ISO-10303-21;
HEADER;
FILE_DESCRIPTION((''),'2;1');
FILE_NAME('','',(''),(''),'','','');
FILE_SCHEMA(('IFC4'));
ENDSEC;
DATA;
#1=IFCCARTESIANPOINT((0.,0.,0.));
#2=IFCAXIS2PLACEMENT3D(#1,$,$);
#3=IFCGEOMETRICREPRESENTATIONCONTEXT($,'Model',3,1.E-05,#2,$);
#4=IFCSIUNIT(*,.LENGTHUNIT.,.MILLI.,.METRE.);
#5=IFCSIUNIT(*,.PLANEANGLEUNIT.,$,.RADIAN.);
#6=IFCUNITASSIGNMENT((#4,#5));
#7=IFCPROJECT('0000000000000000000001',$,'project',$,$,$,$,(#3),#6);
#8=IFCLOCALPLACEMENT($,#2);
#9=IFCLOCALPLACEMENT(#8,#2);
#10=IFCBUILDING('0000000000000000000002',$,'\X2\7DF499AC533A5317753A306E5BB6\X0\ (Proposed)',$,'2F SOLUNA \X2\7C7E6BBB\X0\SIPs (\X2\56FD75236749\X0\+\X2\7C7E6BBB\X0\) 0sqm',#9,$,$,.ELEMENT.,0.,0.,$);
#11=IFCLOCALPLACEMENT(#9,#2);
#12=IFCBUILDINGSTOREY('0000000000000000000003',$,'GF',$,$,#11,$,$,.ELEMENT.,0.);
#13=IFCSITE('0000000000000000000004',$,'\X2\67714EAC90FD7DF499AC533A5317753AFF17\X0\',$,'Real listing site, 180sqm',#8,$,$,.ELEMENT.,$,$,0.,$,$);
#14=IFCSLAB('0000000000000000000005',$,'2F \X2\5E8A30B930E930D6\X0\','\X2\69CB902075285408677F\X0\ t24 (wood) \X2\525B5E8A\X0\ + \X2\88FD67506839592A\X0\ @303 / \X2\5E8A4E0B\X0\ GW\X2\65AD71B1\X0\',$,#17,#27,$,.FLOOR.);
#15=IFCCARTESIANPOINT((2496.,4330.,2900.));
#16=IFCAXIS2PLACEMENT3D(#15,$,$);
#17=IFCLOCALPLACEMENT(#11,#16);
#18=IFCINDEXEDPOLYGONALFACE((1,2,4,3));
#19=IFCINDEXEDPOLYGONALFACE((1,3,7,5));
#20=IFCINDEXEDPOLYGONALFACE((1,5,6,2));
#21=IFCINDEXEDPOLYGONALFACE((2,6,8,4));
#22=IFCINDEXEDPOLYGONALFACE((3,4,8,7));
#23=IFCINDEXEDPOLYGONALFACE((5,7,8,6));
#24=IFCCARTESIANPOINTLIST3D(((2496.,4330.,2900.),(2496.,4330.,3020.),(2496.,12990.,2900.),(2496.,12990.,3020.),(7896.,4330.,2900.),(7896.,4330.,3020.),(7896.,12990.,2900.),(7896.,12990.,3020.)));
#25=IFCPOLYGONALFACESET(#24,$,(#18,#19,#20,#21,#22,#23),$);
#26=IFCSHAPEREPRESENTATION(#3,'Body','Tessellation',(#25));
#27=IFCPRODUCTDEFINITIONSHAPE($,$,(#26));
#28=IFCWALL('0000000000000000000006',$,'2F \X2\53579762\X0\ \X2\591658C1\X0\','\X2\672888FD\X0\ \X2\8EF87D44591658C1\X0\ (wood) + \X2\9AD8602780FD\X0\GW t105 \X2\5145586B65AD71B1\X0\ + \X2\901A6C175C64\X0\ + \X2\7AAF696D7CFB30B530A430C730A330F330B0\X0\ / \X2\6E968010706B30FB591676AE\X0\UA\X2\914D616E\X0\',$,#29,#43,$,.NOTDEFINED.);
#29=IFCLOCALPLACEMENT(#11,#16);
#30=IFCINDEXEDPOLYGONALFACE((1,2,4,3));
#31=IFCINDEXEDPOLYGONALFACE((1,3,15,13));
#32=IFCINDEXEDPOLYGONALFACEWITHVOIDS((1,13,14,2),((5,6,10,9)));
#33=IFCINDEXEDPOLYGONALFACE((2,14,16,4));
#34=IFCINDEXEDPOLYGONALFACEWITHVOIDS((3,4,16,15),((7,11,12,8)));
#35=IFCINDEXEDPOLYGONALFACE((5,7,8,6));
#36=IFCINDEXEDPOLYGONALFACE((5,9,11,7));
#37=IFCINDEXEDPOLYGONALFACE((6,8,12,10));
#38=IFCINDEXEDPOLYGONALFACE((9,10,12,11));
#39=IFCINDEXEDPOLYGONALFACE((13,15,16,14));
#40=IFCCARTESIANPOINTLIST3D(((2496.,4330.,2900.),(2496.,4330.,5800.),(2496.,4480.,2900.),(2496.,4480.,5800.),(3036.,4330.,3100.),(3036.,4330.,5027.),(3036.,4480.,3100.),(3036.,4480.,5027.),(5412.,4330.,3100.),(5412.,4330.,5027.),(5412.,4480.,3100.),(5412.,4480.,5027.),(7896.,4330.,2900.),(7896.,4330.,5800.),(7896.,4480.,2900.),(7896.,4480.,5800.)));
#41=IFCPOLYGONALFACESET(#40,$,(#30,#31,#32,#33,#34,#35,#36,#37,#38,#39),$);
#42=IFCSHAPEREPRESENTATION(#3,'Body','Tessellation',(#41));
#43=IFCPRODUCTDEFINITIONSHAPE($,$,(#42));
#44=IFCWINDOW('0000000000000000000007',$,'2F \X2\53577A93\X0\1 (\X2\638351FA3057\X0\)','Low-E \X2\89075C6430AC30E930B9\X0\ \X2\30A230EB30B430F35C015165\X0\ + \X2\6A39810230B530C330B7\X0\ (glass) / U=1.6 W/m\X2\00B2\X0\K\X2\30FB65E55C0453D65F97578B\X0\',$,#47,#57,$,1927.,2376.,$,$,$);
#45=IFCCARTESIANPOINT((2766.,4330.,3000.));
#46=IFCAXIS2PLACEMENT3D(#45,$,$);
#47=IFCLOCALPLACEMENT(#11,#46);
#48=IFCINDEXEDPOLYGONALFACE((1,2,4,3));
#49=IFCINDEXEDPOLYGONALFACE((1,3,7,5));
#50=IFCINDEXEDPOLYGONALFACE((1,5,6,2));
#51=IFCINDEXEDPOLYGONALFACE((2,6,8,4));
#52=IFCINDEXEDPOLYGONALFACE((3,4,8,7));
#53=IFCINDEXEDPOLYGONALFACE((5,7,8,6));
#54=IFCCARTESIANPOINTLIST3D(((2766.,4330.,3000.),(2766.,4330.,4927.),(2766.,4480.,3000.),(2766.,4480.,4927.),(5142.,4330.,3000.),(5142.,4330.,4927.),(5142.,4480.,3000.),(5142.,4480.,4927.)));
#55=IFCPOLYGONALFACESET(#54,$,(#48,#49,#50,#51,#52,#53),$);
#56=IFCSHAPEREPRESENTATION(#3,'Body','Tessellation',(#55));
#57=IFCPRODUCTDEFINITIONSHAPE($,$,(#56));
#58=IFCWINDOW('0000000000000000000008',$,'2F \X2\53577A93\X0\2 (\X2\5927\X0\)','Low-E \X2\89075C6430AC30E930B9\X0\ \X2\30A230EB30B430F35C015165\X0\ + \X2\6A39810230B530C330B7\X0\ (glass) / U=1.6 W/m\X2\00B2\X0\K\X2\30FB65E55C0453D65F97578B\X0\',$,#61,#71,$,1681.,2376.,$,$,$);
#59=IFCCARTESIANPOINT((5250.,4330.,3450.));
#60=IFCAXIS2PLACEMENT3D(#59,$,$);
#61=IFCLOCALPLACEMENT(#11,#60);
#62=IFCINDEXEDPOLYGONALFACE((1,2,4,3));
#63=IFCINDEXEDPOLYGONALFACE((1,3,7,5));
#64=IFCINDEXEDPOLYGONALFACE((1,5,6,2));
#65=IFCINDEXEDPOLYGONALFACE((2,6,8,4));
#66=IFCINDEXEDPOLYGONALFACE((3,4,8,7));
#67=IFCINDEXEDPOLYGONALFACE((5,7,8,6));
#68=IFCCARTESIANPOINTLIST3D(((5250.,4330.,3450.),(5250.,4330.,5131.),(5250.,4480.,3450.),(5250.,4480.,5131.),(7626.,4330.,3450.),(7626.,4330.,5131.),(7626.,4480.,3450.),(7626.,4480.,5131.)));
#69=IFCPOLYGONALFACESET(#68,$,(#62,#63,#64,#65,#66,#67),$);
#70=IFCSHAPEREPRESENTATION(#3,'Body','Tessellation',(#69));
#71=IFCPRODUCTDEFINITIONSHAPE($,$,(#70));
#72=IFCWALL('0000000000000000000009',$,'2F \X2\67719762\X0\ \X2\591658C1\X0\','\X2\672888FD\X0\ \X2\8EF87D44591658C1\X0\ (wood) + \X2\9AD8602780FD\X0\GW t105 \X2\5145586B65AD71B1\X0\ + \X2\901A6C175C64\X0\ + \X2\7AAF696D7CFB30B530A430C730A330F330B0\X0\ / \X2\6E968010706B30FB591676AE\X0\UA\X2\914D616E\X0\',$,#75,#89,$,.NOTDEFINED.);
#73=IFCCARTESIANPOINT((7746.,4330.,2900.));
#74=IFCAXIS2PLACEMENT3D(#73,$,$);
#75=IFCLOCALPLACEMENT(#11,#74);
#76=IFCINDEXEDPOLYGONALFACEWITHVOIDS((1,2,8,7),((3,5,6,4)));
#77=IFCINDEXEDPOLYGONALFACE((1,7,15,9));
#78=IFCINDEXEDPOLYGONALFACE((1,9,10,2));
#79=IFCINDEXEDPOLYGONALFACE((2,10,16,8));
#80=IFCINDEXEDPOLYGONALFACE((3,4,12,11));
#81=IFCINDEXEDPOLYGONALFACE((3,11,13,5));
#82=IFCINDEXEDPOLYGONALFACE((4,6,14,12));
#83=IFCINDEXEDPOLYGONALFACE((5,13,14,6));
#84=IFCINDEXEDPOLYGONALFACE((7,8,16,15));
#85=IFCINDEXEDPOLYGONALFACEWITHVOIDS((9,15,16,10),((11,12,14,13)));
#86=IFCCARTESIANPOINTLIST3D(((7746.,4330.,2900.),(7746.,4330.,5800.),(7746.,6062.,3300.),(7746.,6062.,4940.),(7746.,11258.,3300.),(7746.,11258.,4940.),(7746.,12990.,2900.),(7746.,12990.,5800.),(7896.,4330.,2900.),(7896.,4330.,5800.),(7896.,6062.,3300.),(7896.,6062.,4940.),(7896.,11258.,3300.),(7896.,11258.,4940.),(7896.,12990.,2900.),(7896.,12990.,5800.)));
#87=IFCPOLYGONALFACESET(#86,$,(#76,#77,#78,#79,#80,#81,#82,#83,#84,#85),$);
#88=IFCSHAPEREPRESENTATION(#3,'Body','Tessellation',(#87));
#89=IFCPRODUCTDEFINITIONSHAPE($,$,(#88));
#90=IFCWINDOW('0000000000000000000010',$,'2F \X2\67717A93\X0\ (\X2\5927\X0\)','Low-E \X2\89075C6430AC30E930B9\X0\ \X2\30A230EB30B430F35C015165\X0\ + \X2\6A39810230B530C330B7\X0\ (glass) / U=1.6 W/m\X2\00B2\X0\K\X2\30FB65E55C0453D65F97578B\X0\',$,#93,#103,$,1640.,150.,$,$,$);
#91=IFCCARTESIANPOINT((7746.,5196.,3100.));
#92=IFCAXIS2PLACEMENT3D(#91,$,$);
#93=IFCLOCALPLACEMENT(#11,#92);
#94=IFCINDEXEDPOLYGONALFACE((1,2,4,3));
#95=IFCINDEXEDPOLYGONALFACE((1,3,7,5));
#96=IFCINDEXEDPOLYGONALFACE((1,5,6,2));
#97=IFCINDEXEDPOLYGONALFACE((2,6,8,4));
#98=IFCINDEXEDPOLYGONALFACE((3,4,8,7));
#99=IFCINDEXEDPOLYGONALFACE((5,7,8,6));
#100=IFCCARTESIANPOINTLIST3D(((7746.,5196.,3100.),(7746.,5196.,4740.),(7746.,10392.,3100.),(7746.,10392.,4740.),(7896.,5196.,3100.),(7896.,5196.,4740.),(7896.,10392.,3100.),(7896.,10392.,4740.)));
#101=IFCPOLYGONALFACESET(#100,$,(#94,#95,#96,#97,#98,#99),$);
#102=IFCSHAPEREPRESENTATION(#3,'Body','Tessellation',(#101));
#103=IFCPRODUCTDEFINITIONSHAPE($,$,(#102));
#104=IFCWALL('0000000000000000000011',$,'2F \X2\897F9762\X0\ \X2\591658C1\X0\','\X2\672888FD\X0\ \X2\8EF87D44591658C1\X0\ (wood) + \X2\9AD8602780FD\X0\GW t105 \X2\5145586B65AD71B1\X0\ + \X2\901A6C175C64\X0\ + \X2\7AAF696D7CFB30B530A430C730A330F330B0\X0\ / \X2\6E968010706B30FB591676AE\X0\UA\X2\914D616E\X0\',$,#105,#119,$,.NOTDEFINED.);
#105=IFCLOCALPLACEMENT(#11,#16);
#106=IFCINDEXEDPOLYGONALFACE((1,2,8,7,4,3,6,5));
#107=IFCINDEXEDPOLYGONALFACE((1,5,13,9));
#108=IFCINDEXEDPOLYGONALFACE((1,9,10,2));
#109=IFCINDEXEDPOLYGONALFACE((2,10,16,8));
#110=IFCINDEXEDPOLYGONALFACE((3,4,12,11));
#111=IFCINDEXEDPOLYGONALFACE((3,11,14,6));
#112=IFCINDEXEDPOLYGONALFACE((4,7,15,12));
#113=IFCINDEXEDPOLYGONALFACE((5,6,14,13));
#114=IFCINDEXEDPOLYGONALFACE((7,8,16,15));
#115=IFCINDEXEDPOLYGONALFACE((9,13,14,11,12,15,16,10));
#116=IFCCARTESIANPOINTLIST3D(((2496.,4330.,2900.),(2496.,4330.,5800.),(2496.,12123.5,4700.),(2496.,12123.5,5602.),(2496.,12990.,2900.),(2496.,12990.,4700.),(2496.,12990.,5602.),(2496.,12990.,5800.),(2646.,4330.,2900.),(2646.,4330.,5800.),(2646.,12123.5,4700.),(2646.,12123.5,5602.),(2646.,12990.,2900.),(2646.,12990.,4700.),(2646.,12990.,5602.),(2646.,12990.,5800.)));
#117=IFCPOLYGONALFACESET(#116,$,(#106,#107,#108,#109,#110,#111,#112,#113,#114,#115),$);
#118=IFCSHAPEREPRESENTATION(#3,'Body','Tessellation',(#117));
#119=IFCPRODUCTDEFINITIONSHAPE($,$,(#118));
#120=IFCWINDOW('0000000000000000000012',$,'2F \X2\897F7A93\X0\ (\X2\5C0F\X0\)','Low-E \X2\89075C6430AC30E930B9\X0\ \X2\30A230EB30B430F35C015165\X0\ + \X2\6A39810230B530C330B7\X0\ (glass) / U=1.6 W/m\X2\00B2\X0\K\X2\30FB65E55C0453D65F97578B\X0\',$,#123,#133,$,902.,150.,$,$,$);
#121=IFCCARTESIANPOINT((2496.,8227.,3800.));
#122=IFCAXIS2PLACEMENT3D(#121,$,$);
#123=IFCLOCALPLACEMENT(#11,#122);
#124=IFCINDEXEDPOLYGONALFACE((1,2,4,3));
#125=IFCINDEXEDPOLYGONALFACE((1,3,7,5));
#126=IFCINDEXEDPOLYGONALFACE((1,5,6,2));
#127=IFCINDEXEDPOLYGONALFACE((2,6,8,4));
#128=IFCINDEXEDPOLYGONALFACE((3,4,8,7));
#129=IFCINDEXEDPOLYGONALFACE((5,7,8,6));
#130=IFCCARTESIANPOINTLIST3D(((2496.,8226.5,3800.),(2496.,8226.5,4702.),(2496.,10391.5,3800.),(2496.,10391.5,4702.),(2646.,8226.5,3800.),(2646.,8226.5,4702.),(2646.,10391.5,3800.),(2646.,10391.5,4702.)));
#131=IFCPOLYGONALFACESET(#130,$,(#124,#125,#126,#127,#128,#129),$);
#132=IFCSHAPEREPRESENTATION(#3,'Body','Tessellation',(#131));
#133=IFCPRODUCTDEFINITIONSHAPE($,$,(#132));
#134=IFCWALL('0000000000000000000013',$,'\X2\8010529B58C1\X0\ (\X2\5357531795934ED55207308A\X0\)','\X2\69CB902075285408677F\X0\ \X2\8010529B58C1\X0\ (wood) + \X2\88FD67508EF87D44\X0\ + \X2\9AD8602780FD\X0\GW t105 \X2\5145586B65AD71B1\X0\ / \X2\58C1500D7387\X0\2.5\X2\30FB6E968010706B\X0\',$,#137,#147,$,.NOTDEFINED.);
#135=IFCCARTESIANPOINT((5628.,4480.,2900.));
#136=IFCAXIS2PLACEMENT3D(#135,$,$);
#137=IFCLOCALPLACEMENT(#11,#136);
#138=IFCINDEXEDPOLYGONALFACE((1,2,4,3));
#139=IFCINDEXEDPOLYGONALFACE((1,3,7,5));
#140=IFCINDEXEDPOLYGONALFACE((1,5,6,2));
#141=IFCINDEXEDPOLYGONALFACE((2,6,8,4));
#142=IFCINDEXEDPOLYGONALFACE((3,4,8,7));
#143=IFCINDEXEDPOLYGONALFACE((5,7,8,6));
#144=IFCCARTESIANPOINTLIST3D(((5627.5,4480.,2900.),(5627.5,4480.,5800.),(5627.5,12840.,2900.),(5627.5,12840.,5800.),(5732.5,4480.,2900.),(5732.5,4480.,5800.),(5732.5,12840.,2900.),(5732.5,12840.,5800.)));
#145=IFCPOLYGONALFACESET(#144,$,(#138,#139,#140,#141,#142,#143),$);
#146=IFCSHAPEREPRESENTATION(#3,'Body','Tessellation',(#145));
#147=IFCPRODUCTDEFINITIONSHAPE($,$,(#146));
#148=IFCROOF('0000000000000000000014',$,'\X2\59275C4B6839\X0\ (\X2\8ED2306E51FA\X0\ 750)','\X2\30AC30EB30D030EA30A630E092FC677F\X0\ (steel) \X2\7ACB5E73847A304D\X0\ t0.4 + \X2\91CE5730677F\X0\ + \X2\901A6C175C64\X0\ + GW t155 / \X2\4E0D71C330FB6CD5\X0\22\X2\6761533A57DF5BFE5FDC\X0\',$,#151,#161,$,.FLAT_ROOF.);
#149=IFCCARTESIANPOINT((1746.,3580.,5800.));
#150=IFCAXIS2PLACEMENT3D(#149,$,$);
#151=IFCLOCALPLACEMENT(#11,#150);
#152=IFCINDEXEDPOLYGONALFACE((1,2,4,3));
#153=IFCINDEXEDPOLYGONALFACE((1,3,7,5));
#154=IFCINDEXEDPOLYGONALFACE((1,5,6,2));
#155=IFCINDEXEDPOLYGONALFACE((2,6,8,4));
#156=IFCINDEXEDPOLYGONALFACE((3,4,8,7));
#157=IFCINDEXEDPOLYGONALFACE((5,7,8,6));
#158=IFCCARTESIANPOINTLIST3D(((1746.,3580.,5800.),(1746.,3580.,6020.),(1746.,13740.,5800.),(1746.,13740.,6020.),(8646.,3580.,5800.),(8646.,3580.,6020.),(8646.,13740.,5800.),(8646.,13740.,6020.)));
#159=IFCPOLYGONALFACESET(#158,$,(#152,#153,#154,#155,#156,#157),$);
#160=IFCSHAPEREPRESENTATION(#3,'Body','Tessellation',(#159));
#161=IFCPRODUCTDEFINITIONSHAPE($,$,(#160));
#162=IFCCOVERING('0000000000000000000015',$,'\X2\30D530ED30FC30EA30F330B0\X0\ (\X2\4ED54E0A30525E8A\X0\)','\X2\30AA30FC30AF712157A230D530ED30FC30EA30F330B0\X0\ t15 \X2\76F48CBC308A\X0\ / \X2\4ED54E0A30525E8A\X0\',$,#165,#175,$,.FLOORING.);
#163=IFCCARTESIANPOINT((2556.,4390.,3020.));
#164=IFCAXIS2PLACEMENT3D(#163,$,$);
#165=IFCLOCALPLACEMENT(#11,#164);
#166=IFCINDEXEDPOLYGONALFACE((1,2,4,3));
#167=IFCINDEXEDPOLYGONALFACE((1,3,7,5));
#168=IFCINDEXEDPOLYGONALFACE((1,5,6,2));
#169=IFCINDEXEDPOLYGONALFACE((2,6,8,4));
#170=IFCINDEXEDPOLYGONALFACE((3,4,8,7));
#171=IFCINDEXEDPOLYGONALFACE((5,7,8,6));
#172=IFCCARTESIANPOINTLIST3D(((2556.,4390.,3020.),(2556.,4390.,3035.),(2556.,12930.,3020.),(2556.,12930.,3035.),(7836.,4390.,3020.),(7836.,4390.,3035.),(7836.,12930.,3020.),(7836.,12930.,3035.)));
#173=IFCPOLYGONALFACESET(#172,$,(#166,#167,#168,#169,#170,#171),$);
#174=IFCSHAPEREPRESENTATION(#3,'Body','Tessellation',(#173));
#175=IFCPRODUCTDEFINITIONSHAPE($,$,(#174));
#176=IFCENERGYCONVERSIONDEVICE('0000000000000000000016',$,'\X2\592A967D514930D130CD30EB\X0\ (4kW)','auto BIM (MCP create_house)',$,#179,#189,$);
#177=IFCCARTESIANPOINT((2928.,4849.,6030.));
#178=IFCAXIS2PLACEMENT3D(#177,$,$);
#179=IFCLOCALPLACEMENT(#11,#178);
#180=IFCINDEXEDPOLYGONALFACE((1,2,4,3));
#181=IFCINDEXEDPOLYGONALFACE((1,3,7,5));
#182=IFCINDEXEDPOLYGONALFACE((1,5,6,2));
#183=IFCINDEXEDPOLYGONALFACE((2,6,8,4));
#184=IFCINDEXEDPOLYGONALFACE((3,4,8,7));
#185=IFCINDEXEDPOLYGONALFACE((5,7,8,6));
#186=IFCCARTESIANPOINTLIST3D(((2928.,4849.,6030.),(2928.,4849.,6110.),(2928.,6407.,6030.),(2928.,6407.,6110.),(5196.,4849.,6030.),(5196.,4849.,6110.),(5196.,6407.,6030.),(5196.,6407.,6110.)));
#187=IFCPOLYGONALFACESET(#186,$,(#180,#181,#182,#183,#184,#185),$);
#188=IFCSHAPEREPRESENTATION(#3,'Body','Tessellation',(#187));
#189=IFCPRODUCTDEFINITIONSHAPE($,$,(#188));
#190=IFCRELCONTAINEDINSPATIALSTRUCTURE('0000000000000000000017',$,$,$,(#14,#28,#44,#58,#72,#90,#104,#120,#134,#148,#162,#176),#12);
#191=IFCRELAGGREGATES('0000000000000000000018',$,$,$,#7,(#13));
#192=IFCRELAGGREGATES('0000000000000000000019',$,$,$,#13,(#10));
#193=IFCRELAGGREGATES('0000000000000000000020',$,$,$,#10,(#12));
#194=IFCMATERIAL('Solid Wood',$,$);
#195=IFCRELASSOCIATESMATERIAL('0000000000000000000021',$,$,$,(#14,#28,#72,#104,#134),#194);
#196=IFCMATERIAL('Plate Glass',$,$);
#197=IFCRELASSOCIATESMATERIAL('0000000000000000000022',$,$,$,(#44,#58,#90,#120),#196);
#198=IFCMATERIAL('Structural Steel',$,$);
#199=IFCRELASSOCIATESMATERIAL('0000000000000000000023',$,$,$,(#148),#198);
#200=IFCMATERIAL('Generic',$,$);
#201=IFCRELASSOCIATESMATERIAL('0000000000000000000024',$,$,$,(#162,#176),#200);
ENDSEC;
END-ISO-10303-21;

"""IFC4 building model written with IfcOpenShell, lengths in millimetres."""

from ifc_helpers import new_model, si_unit, frame, frame_2d, origin, place, context, project, spatial, rectangle, extrude, material, element, fill, save


model = new_model("IFC4")

# Units and contexts
model_context = context("Model", 3, precision=1e-05, world=origin())
ifc_project = project(units=[si_unit("LENGTHUNIT", "METRE", prefix="MILLI"), si_unit("PLANEANGLEUNIT", "RADIAN")], contexts=[model_context])

# Site, building, storey
site_placement = place(None, origin())
site = spatial("IfcSite", under=ifc_project, at=site_placement, Name="東京都練馬区北町７", ObjectType="Real listing site, 180sqm", CompositionType="ELEMENT", RefElevation=0.0)
building_placement = place(site_placement, origin())
building = spatial("IfcBuilding", under=site, at=building_placement, Name="練馬区北町の家 (Proposed)", ObjectType="2F SOLUNA 籾殻SIPs (国産杉+籾殻) 0sqm", CompositionType="ELEMENT", ElevationOfRefHeight=0.0, ElevationOfTerrain=0.0)
storey_placement = place(building_placement, origin())
storey = spatial("IfcBuildingStorey", under=building, at=storey_placement, Name="GF", CompositionType="ELEMENT", Elevation=0.0)

# Slab
ifc_material_1 = material(Name="Solid Wood")
slab_placement = place(storey_placement, frame((2496.0, 4330.0, 2900.0)))
element("IfcSlab", 1, at=slab_placement, inside=storey, material=ifc_material_1, Name="2F 床スラブ", Description="構造用合板 t24 (wood) 剛床 + 製材根太 @303 / 床下 GW断熱", PredefinedType="FLOOR", context=model_context, shape_type="SweptSolid", body=[
    extrude(rectangle(XDim=5400.0, YDim=8660.0, at=frame_2d((2700.0, 4330.0))), frame((2496.0, 4330.0, 2900.0)), (0.0, 0.0, 1.0), 120.0),
])

# Wall, openings, windows
wall_1_placement = place(storey_placement, frame((2496.0, 4330.0, 2900.0)))
wall_1 = element("IfcWall", 2, at=wall_1_placement, inside=storey, material=ifc_material_1, Name="2F 南面 外壁", Description="木製 軸組外壁 (wood) + 高性能GW t105 充填断熱 + 通気層 + 窯業系サイディング / 準耐火・外皮UA配慮", PredefinedType="NOTDEFINED", context=model_context, shape_type="SweptSolid", body=[
    extrude(rectangle(XDim=5400.0, YDim=150.0, at=frame_2d((2700.0, 75.0))), frame((2496.0, 4330.0, 2900.0)), (0.0, 0.0, 1.0), 2900.0),
])
opening_1_placement = place(storey_placement, frame((2766.0, 4330.0, 3000.0)))
opening_1 = element("IfcOpeningElement", 3, at=opening_1_placement, cuts=wall_1, PredefinedType="NOTDEFINED", context=model_context, shape_type="SweptSolid", body=[
    extrude(rectangle(XDim=2376.0, YDim=150.0, at=frame_2d((1188.0, 75.0))), frame((2766.0, 4330.0, 3000.0)), (0.0, 0.0, 1.0), 1927.0),
])
opening_2_placement = place(storey_placement, frame((5250.0, 4330.0, 3450.0)))
opening_2 = element("IfcOpeningElement", 4, at=opening_2_placement, cuts=wall_1, PredefinedType="NOTDEFINED", context=model_context, shape_type="SweptSolid", body=[
    extrude(rectangle(XDim=2376.0, YDim=150.0, at=frame_2d((1188.0, 75.0))), frame((5250.0, 4330.0, 3450.0)), (0.0, 0.0, 1.0), 1681.0),
])
ifc_material_2 = material(Name="Plate Glass")
window_1_placement = place(storey_placement, frame((2766.0, 4330.0, 3000.0)))
window_1 = element("IfcWindow", 5, at=window_1_placement, inside=storey, material=ifc_material_2, Name="2F 南窓1 (掃出し)", Description="Low-E 複層ガラス アルゴン封入 + 樹脂サッシ (glass) / U=1.6 W/m²K・日射取得型", OverallHeight=1927.0, OverallWidth=2376.0, context=model_context, shape_type="SweptSolid", body=[
    extrude(rectangle(XDim=2376.0, YDim=150.0, at=frame_2d((1188.0, 75.0))), frame((2766.0, 4330.0, 3000.0)), (0.0, 0.0, 1.0), 1927.0),
])
fill(opening_1, window_1)
window_2_placement = place(storey_placement, frame((5250.0, 4330.0, 3450.0)))
window_2 = element("IfcWindow", 6, at=window_2_placement, inside=storey, material=ifc_material_2, Name="2F 南窓2 (大)", Description="Low-E 複層ガラス アルゴン封入 + 樹脂サッシ (glass) / U=1.6 W/m²K・日射取得型", OverallHeight=1681.0, OverallWidth=2376.0, context=model_context, shape_type="SweptSolid", body=[
    extrude(rectangle(XDim=2376.0, YDim=150.0, at=frame_2d((1188.0, 75.0))), frame((5250.0, 4330.0, 3450.0)), (0.0, 0.0, 1.0), 1681.0),
])
fill(opening_2, window_2)

# Walls, openings, windows
wall_2_placement = place(storey_placement, frame((7746.0, 4330.0, 2900.0)))
wall_2 = element("IfcWall", 7, at=wall_2_placement, inside=storey, material=ifc_material_1, Name="2F 東面 外壁", Description="木製 軸組外壁 (wood) + 高性能GW t105 充填断熱 + 通気層 + 窯業系サイディング / 準耐火・外皮UA配慮", PredefinedType="NOTDEFINED", context=model_context, shape_type="SweptSolid", body=[
    extrude(rectangle(XDim=150.0, YDim=8660.0, at=frame_2d((75.0, 4330.0))), frame((7746.0, 4330.0, 2900.0)), (0.0, 0.0, 1.0), 2900.0),
])
opening_3_placement = place(storey_placement, frame((7746.0, 5196.0, 3100.0)))
opening_3 = element("IfcOpeningElement", 8, at=opening_3_placement, cuts=wall_2, PredefinedType="NOTDEFINED", context=model_context, shape_type="SweptSolid", body=[
    extrude(rectangle(XDim=150.0, YDim=5196.0, at=frame_2d((75.0, 2598.0))), frame((7746.0, 5196.0, 3100.0)), (0.0, 0.0, 1.0), 1640.0),
])
window_3_placement = place(storey_placement, frame((7746.0, 5196.0, 3100.0)))
window_3 = element("IfcWindow", 9, at=window_3_placement, inside=storey, material=ifc_material_2, Name="2F 東窓 (大)", Description="Low-E 複層ガラス アルゴン封入 + 樹脂サッシ (glass) / U=1.6 W/m²K・日射取得型", OverallHeight=1640.0, OverallWidth=150.0, context=model_context, shape_type="SweptSolid", body=[
    extrude(rectangle(XDim=150.0, YDim=5196.0, at=frame_2d((75.0, 2598.0))), frame((7746.0, 5196.0, 3100.0)), (0.0, 0.0, 1.0), 1640.0),
])
fill(opening_3, window_3)
wall_3_placement = place(storey_placement, frame((2496.0, 4330.0, 2900.0)))
wall_3 = element("IfcWall", 10, at=wall_3_placement, inside=storey, material=ifc_material_1, Name="2F 西面 外壁", Description="木製 軸組外壁 (wood) + 高性能GW t105 充填断熱 + 通気層 + 窯業系サイディング / 準耐火・外皮UA配慮", PredefinedType="NOTDEFINED", context=model_context, shape_type="SweptSolid", body=[
    extrude(rectangle(XDim=150.0, YDim=8660.0, at=frame_2d((75.0, 4330.0))), frame((2496.0, 4330.0, 2900.0)), (0.0, 0.0, 1.0), 2900.0),
])
opening_4_placement = place(storey_placement, frame((2496.0, 8227.0, 3800.0)))
opening_4 = element("IfcOpeningElement", 11, at=opening_4_placement, cuts=wall_3, PredefinedType="NOTDEFINED", context=model_context, shape_type="SweptSolid", body=[
    extrude(rectangle(XDim=150.0, YDim=2165.0, at=frame_2d((75.0, 1082.0))), frame((2496.0, 8227.0, 3800.0)), (0.0, 0.0, 1.0), 902.0),
])
window_4_placement = place(storey_placement, frame((2496.0, 8227.0, 3800.0)))
window_4 = element("IfcWindow", 12, at=window_4_placement, inside=storey, material=ifc_material_2, Name="2F 西窓 (小)", Description="Low-E 複層ガラス アルゴン封入 + 樹脂サッシ (glass) / U=1.6 W/m²K・日射取得型", OverallHeight=902.0, OverallWidth=150.0, context=model_context, shape_type="SweptSolid", body=[
    extrude(rectangle(XDim=150.0, YDim=2165.0, at=frame_2d((75.0, 1082.0))), frame((2496.0, 8227.0, 3800.0)), (0.0, 0.0, 1.0), 902.0),
])
fill(opening_4, window_4)

# Wall
wall_4_placement = place(storey_placement, frame((5628.0, 4480.0, 2900.0)))
element("IfcWall", 13, at=wall_4_placement, inside=storey, material=ifc_material_1, Name="耐力壁 (南北間仕切り)", Description="構造用合板 耐力壁 (wood) + 製材軸組 + 高性能GW t105 充填断熱 / 壁倍率2.5・準耐火", PredefinedType="NOTDEFINED", context=model_context, shape_type="SweptSolid", body=[
    extrude(rectangle(XDim=105.0, YDim=8360.0, at=frame_2d((52.0, 4180.0))), frame((5628.0, 4480.0, 2900.0)), (0.0, 0.0, 1.0), 2900.0),
])

# Roof
ifc_material_3 = material(Name="Structural Steel")
roof_placement = place(storey_placement, frame((1746.0, 3580.0, 5800.0)))
element("IfcRoof", 14, at=roof_placement, inside=storey, material=ifc_material_3, Name="大屋根 (軒の出 750)", Description="ガルバリウム鋼板 (steel) 立平葺き t0.4 + 野地板 + 通気層 + GW t155 / 不燃・法22条区域対応", PredefinedType="FLAT_ROOF", context=model_context, shape_type="SweptSolid", body=[
    extrude(rectangle(XDim=6900.0, YDim=10160.0, at=frame_2d((3450.0, 5080.0))), frame((1746.0, 3580.0, 5800.0)), (0.0, 0.0, 1.0), 220.0),
])

# Covering
ifc_material_4 = material(Name="Generic")
covering_placement = place(storey_placement, frame((2556.0, 4390.0, 3020.0)))
element("IfcCovering", 15, at=covering_placement, inside=storey, material=ifc_material_4, Name="フローリング (仕上げ床)", Description="オーク無垢フローリング t15 直貼り / 仕上げ床", PredefinedType="FLOORING", context=model_context, shape_type="SweptSolid", body=[
    extrude(rectangle(XDim=5280.0, YDim=8540.0, at=frame_2d((2640.0, 4270.0))), frame((2556.0, 4390.0, 3020.0)), (0.0, 0.0, 1.0), 15.0),
])

# Energy conversion device
energy_conversion_device_placement = place(storey_placement, frame((2928.0, 4849.0, 6030.0)))
element("IfcEnergyConversionDevice", 16, at=energy_conversion_device_placement, inside=storey, material=ifc_material_4, Name="太陽光パネル (4kW)", Description="auto BIM (MCP create_house)", context=model_context, shape_type="SweptSolid", body=[
    extrude(rectangle(XDim=2268.0, YDim=1558.0, at=frame_2d((1134.0, 779.0))), frame((2928.0, 4849.0, 6030.0)), (0.0, 0.0, 1.0), 80.0),
])

save(model, "model.ifc")
